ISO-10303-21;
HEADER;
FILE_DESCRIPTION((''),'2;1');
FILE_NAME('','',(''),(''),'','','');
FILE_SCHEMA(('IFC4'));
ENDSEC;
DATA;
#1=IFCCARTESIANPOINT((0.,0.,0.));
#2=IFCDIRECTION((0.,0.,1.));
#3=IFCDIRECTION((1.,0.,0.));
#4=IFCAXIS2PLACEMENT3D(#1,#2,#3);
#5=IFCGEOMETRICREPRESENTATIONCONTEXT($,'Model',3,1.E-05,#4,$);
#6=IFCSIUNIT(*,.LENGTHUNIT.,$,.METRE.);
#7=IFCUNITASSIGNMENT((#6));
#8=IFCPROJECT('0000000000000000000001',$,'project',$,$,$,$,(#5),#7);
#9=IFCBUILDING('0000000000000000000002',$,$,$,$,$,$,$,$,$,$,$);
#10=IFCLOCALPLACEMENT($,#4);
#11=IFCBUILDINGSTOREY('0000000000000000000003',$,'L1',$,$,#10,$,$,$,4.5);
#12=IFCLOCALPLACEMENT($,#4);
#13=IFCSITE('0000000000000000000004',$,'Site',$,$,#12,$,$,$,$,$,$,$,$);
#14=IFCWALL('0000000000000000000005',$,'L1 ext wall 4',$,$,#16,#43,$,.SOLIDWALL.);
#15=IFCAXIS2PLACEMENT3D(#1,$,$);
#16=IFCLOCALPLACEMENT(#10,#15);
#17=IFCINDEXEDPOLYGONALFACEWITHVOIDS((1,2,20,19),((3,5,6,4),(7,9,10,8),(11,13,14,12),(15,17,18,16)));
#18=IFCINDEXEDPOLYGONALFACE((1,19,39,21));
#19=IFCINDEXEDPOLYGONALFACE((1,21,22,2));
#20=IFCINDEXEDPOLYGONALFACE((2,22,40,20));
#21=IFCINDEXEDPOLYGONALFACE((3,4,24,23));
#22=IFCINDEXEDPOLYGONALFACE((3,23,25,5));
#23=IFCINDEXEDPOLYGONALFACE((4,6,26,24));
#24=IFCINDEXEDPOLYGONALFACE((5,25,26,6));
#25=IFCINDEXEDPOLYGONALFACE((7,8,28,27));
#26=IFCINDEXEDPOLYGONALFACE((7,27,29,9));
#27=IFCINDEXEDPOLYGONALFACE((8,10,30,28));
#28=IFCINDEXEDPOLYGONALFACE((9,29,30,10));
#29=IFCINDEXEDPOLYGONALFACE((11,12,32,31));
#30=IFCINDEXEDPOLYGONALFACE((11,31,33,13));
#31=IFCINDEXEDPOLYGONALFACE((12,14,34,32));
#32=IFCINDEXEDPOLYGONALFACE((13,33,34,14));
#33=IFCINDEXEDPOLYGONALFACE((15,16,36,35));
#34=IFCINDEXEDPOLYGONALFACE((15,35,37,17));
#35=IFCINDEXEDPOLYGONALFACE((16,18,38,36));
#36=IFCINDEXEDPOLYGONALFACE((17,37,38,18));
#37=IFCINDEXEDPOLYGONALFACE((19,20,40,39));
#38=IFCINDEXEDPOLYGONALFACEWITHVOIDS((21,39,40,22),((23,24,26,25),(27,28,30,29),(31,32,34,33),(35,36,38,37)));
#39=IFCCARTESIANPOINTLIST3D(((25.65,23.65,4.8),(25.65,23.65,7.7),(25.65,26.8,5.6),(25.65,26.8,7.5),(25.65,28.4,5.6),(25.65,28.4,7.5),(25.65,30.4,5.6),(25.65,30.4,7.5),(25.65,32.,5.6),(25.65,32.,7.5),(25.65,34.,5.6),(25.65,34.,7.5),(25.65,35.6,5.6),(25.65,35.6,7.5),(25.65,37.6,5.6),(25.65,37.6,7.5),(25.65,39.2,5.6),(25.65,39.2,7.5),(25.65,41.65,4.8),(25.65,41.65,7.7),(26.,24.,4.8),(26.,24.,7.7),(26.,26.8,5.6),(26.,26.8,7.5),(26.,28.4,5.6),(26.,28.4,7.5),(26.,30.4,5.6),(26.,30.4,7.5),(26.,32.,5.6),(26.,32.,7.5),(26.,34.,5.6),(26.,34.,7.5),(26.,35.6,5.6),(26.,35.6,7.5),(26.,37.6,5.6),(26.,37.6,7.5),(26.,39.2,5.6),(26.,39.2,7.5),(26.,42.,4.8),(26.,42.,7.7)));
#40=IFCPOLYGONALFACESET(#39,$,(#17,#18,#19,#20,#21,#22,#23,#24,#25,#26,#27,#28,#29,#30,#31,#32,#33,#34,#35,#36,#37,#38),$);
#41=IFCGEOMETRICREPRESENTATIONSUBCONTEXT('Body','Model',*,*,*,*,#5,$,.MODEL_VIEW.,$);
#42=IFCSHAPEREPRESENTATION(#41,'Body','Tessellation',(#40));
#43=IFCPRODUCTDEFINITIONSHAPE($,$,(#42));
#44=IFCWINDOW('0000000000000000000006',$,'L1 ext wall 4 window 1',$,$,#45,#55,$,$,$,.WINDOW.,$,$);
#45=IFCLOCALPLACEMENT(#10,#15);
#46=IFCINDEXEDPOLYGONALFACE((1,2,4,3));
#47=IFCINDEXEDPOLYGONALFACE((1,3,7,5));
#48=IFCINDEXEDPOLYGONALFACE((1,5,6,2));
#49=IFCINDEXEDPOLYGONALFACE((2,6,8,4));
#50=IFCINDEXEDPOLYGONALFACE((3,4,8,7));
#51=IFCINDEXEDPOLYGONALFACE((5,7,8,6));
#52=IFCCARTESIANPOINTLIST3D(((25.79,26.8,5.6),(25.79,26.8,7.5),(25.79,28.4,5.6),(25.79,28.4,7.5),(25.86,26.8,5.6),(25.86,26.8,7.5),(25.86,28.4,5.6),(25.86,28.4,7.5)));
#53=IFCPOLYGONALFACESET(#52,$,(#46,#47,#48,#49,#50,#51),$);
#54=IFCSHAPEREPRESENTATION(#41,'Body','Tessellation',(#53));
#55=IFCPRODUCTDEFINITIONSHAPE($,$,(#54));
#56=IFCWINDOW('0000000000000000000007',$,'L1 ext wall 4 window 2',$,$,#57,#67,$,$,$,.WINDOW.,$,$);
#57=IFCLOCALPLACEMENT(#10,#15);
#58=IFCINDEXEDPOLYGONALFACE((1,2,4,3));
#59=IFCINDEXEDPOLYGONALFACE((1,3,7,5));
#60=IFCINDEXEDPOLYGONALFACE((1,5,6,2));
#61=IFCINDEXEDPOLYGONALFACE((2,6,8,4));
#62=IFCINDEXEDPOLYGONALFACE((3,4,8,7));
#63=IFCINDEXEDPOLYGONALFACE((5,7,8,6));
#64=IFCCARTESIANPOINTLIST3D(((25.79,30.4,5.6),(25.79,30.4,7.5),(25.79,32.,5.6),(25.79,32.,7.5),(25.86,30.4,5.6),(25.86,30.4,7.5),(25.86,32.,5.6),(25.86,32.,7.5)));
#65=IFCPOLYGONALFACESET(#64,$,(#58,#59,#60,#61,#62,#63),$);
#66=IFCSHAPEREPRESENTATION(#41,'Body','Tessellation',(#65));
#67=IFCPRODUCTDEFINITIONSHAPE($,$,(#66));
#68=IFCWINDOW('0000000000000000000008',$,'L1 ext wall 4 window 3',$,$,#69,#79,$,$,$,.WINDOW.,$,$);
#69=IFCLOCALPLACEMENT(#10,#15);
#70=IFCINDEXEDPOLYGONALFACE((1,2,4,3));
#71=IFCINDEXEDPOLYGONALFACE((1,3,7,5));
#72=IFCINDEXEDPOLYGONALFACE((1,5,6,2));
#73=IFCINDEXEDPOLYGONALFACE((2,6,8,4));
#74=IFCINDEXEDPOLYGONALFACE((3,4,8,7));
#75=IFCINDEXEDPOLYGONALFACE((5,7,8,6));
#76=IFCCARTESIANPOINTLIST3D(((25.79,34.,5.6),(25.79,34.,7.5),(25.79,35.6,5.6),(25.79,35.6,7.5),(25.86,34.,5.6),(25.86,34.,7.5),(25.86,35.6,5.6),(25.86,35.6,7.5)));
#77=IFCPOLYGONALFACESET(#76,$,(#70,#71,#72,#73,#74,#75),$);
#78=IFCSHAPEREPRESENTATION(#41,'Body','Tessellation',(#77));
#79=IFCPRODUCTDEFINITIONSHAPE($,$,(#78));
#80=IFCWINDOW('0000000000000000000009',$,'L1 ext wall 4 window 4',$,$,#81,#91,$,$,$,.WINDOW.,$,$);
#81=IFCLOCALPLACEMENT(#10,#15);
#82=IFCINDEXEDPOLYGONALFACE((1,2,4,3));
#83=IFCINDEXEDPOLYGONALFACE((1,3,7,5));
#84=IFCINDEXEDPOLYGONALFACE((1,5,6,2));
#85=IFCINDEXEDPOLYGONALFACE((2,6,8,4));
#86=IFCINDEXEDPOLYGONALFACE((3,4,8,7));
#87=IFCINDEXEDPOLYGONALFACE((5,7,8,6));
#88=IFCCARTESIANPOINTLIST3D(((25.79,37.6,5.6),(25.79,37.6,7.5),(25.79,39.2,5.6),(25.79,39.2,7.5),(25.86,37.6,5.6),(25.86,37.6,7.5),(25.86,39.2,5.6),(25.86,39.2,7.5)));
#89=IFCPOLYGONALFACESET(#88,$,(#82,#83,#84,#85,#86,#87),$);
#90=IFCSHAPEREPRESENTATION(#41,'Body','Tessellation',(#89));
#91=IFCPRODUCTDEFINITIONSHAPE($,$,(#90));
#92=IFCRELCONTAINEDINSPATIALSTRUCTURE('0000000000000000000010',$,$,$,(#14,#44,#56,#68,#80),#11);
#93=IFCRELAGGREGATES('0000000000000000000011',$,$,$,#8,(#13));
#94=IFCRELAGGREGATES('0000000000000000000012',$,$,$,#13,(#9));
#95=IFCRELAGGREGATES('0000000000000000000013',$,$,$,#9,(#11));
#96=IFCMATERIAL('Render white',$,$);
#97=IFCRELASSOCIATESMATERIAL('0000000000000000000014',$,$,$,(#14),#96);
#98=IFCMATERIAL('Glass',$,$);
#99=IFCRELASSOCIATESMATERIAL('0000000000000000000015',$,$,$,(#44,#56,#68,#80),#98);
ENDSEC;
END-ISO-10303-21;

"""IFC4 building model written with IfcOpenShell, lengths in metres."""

from ifc_helpers import new_model, si_unit, frame, origin_with_axes, place, context, subcontext, project, spatial, polyline, outline, extrude, material, element, fill, save


model = new_model("IFC4")

# Units and contexts
model_context = context("Model", 3, precision=1e-05, world=origin_with_axes())
body_context = subcontext(model_context, "Body", "Model", "MODEL_VIEW")
ifc_project = project(units=[si_unit("LENGTHUNIT", "METRE")], contexts=[model_context])

# Site, building, storey
site_placement = place(None, origin_with_axes())
site = spatial("IfcSite", under=ifc_project, at=site_placement, Name="Site")
building = spatial("IfcBuilding", under=site)
storey_placement = place(None, origin_with_axes())
storey = spatial("IfcBuildingStorey", under=building, at=storey_placement, Name="L1", Elevation=4.5)

# Wall, openings, windows
ifc_material_1 = material(Name="Render white")
ifc_material_2 = material(Name="Glass")
wall_1_placement = place(storey_placement, origin_with_axes())
wall_1 = element("IfcWall", 1, at=wall_1_placement, inside=storey, material=ifc_material_1, Name="L1 ext wall 4", PredefinedType="SOLIDWALL", context=body_context, shape_type="SweptSolid", body=[
    extrude(outline(polyline([(26.0, 24.0), (26.0, 42.0), (25.65, 41.65), (25.65, 23.65), (26.0, 24.0)])), frame((0.0, 0.0, 4.8), z_axis=(0.0, 0.0, 1.0), x_axis=(1.0, 0.0, 0.0)), (0.0, 0.0, 1.0), 2.9),
])
opening_1_placement = place(wall_1_placement, origin_with_axes())
opening_1 = element("IfcOpeningElement", 2, at=opening_1_placement, cuts=wall_1, context=body_context, shape_type="SweptSolid", body=[
    extrude(outline(polyline([(26.05, 26.8), (26.05, 28.4), (25.6, 28.4), (25.6, 26.8), (26.05, 26.8)])), frame((0.0, 0.0, 5.6), z_axis=(0.0, 0.0, 1.0), x_axis=(1.0, 0.0, 0.0)), (0.0, 0.0, 1.0), 1.9),
])
opening_2_placement = place(wall_1_placement, origin_with_axes())
opening_2 = element("IfcOpeningElement", 3, at=opening_2_placement, cuts=wall_1, context=body_context, shape_type="SweptSolid", body=[
    extrude(outline(polyline([(26.05, 30.4), (26.05, 32.0), (25.6, 32.0), (25.6, 30.4), (26.05, 30.4)])), frame((0.0, 0.0, 5.6), z_axis=(0.0, 0.0, 1.0), x_axis=(1.0, 0.0, 0.0)), (0.0, 0.0, 1.0), 1.9),
])
opening_3_placement = place(wall_1_placement, origin_with_axes())
opening_3 = element("IfcOpeningElement", 4, at=opening_3_placement, cuts=wall_1, context=body_context, shape_type="SweptSolid", body=[
    extrude(outline(polyline([(26.05, 34.0), (26.05, 35.6), (25.6, 35.6), (25.6, 34.0), (26.05, 34.0)])), frame((0.0, 0.0, 5.6), z_axis=(0.0, 0.0, 1.0), x_axis=(1.0, 0.0, 0.0)), (0.0, 0.0, 1.0), 1.9),
])
opening_4_placement = place(wall_1_placement, origin_with_axes())
opening_4 = element("IfcOpeningElement", 5, at=opening_4_placement, cuts=wall_1, context=body_context, shape_type="SweptSolid", body=[
    extrude(outline(polyline([(26.05, 37.6), (26.05, 39.2), (25.6, 39.2), (25.6, 37.6), (26.05, 37.6)])), frame((0.0, 0.0, 5.6), z_axis=(0.0, 0.0, 1.0), x_axis=(1.0, 0.0, 0.0)), (0.0, 0.0, 1.0), 1.9),
])
window_1_placement = place(storey_placement, origin_with_axes())
window_1 = element("IfcWindow", 6, at=window_1_placement, inside=storey, material=ifc_material_2, Name="L1 ext wall 4 window 1", PredefinedType="WINDOW", context=body_context, shape_type="SweptSolid", body=[
    extrude(outline(polyline([(25.86, 26.8), (25.86, 28.4), (25.79, 28.4), (25.79, 26.8), (25.86, 26.8)])), frame((0.0, 0.0, 5.6), z_axis=(0.0, 0.0, 1.0), x_axis=(1.0, 0.0, 0.0)), (0.0, 0.0, 1.0), 1.9),
])
fill(opening_1, window_1)
window_2_placement = place(storey_placement, origin_with_axes())
window_2 = element("IfcWindow", 7, at=window_2_placement, inside=storey, material=ifc_material_2, Name="L1 ext wall 4 window 2", PredefinedType="WINDOW", context=body_context, shape_type="SweptSolid", body=[
    extrude(outline(polyline([(25.86, 30.4), (25.86, 32.0), (25.79, 32.0), (25.79, 30.4), (25.86, 30.4)])), frame((0.0, 0.0, 5.6), z_axis=(0.0, 0.0, 1.0), x_axis=(1.0, 0.0, 0.0)), (0.0, 0.0, 1.0), 1.9),
])
fill(opening_2, window_2)
window_3_placement = place(storey_placement, origin_with_axes())
window_3 = element("IfcWindow", 8, at=window_3_placement, inside=storey, material=ifc_material_2, Name="L1 ext wall 4 window 3", PredefinedType="WINDOW", context=body_context, shape_type="SweptSolid", body=[
    extrude(outline(polyline([(25.86, 34.0), (25.86, 35.6), (25.79, 35.6), (25.79, 34.0), (25.86, 34.0)])), frame((0.0, 0.0, 5.6), z_axis=(0.0, 0.0, 1.0), x_axis=(1.0, 0.0, 0.0)), (0.0, 0.0, 1.0), 1.9),
])
fill(opening_3, window_3)
window_4_placement = place(storey_placement, origin_with_axes())
window_4 = element("IfcWindow", 9, at=window_4_placement, inside=storey, material=ifc_material_2, Name="L1 ext wall 4 window 4", PredefinedType="WINDOW", context=body_context, shape_type="SweptSolid", body=[
    extrude(outline(polyline([(25.86, 37.6), (25.86, 39.2), (25.79, 39.2), (25.79, 37.6), (25.86, 37.6)])), frame((0.0, 0.0, 5.6), z_axis=(0.0, 0.0, 1.0), x_axis=(1.0, 0.0, 0.0)), (0.0, 0.0, 1.0), 1.9),
])
fill(opening_4, window_4)

save(model, "model.ifc")
